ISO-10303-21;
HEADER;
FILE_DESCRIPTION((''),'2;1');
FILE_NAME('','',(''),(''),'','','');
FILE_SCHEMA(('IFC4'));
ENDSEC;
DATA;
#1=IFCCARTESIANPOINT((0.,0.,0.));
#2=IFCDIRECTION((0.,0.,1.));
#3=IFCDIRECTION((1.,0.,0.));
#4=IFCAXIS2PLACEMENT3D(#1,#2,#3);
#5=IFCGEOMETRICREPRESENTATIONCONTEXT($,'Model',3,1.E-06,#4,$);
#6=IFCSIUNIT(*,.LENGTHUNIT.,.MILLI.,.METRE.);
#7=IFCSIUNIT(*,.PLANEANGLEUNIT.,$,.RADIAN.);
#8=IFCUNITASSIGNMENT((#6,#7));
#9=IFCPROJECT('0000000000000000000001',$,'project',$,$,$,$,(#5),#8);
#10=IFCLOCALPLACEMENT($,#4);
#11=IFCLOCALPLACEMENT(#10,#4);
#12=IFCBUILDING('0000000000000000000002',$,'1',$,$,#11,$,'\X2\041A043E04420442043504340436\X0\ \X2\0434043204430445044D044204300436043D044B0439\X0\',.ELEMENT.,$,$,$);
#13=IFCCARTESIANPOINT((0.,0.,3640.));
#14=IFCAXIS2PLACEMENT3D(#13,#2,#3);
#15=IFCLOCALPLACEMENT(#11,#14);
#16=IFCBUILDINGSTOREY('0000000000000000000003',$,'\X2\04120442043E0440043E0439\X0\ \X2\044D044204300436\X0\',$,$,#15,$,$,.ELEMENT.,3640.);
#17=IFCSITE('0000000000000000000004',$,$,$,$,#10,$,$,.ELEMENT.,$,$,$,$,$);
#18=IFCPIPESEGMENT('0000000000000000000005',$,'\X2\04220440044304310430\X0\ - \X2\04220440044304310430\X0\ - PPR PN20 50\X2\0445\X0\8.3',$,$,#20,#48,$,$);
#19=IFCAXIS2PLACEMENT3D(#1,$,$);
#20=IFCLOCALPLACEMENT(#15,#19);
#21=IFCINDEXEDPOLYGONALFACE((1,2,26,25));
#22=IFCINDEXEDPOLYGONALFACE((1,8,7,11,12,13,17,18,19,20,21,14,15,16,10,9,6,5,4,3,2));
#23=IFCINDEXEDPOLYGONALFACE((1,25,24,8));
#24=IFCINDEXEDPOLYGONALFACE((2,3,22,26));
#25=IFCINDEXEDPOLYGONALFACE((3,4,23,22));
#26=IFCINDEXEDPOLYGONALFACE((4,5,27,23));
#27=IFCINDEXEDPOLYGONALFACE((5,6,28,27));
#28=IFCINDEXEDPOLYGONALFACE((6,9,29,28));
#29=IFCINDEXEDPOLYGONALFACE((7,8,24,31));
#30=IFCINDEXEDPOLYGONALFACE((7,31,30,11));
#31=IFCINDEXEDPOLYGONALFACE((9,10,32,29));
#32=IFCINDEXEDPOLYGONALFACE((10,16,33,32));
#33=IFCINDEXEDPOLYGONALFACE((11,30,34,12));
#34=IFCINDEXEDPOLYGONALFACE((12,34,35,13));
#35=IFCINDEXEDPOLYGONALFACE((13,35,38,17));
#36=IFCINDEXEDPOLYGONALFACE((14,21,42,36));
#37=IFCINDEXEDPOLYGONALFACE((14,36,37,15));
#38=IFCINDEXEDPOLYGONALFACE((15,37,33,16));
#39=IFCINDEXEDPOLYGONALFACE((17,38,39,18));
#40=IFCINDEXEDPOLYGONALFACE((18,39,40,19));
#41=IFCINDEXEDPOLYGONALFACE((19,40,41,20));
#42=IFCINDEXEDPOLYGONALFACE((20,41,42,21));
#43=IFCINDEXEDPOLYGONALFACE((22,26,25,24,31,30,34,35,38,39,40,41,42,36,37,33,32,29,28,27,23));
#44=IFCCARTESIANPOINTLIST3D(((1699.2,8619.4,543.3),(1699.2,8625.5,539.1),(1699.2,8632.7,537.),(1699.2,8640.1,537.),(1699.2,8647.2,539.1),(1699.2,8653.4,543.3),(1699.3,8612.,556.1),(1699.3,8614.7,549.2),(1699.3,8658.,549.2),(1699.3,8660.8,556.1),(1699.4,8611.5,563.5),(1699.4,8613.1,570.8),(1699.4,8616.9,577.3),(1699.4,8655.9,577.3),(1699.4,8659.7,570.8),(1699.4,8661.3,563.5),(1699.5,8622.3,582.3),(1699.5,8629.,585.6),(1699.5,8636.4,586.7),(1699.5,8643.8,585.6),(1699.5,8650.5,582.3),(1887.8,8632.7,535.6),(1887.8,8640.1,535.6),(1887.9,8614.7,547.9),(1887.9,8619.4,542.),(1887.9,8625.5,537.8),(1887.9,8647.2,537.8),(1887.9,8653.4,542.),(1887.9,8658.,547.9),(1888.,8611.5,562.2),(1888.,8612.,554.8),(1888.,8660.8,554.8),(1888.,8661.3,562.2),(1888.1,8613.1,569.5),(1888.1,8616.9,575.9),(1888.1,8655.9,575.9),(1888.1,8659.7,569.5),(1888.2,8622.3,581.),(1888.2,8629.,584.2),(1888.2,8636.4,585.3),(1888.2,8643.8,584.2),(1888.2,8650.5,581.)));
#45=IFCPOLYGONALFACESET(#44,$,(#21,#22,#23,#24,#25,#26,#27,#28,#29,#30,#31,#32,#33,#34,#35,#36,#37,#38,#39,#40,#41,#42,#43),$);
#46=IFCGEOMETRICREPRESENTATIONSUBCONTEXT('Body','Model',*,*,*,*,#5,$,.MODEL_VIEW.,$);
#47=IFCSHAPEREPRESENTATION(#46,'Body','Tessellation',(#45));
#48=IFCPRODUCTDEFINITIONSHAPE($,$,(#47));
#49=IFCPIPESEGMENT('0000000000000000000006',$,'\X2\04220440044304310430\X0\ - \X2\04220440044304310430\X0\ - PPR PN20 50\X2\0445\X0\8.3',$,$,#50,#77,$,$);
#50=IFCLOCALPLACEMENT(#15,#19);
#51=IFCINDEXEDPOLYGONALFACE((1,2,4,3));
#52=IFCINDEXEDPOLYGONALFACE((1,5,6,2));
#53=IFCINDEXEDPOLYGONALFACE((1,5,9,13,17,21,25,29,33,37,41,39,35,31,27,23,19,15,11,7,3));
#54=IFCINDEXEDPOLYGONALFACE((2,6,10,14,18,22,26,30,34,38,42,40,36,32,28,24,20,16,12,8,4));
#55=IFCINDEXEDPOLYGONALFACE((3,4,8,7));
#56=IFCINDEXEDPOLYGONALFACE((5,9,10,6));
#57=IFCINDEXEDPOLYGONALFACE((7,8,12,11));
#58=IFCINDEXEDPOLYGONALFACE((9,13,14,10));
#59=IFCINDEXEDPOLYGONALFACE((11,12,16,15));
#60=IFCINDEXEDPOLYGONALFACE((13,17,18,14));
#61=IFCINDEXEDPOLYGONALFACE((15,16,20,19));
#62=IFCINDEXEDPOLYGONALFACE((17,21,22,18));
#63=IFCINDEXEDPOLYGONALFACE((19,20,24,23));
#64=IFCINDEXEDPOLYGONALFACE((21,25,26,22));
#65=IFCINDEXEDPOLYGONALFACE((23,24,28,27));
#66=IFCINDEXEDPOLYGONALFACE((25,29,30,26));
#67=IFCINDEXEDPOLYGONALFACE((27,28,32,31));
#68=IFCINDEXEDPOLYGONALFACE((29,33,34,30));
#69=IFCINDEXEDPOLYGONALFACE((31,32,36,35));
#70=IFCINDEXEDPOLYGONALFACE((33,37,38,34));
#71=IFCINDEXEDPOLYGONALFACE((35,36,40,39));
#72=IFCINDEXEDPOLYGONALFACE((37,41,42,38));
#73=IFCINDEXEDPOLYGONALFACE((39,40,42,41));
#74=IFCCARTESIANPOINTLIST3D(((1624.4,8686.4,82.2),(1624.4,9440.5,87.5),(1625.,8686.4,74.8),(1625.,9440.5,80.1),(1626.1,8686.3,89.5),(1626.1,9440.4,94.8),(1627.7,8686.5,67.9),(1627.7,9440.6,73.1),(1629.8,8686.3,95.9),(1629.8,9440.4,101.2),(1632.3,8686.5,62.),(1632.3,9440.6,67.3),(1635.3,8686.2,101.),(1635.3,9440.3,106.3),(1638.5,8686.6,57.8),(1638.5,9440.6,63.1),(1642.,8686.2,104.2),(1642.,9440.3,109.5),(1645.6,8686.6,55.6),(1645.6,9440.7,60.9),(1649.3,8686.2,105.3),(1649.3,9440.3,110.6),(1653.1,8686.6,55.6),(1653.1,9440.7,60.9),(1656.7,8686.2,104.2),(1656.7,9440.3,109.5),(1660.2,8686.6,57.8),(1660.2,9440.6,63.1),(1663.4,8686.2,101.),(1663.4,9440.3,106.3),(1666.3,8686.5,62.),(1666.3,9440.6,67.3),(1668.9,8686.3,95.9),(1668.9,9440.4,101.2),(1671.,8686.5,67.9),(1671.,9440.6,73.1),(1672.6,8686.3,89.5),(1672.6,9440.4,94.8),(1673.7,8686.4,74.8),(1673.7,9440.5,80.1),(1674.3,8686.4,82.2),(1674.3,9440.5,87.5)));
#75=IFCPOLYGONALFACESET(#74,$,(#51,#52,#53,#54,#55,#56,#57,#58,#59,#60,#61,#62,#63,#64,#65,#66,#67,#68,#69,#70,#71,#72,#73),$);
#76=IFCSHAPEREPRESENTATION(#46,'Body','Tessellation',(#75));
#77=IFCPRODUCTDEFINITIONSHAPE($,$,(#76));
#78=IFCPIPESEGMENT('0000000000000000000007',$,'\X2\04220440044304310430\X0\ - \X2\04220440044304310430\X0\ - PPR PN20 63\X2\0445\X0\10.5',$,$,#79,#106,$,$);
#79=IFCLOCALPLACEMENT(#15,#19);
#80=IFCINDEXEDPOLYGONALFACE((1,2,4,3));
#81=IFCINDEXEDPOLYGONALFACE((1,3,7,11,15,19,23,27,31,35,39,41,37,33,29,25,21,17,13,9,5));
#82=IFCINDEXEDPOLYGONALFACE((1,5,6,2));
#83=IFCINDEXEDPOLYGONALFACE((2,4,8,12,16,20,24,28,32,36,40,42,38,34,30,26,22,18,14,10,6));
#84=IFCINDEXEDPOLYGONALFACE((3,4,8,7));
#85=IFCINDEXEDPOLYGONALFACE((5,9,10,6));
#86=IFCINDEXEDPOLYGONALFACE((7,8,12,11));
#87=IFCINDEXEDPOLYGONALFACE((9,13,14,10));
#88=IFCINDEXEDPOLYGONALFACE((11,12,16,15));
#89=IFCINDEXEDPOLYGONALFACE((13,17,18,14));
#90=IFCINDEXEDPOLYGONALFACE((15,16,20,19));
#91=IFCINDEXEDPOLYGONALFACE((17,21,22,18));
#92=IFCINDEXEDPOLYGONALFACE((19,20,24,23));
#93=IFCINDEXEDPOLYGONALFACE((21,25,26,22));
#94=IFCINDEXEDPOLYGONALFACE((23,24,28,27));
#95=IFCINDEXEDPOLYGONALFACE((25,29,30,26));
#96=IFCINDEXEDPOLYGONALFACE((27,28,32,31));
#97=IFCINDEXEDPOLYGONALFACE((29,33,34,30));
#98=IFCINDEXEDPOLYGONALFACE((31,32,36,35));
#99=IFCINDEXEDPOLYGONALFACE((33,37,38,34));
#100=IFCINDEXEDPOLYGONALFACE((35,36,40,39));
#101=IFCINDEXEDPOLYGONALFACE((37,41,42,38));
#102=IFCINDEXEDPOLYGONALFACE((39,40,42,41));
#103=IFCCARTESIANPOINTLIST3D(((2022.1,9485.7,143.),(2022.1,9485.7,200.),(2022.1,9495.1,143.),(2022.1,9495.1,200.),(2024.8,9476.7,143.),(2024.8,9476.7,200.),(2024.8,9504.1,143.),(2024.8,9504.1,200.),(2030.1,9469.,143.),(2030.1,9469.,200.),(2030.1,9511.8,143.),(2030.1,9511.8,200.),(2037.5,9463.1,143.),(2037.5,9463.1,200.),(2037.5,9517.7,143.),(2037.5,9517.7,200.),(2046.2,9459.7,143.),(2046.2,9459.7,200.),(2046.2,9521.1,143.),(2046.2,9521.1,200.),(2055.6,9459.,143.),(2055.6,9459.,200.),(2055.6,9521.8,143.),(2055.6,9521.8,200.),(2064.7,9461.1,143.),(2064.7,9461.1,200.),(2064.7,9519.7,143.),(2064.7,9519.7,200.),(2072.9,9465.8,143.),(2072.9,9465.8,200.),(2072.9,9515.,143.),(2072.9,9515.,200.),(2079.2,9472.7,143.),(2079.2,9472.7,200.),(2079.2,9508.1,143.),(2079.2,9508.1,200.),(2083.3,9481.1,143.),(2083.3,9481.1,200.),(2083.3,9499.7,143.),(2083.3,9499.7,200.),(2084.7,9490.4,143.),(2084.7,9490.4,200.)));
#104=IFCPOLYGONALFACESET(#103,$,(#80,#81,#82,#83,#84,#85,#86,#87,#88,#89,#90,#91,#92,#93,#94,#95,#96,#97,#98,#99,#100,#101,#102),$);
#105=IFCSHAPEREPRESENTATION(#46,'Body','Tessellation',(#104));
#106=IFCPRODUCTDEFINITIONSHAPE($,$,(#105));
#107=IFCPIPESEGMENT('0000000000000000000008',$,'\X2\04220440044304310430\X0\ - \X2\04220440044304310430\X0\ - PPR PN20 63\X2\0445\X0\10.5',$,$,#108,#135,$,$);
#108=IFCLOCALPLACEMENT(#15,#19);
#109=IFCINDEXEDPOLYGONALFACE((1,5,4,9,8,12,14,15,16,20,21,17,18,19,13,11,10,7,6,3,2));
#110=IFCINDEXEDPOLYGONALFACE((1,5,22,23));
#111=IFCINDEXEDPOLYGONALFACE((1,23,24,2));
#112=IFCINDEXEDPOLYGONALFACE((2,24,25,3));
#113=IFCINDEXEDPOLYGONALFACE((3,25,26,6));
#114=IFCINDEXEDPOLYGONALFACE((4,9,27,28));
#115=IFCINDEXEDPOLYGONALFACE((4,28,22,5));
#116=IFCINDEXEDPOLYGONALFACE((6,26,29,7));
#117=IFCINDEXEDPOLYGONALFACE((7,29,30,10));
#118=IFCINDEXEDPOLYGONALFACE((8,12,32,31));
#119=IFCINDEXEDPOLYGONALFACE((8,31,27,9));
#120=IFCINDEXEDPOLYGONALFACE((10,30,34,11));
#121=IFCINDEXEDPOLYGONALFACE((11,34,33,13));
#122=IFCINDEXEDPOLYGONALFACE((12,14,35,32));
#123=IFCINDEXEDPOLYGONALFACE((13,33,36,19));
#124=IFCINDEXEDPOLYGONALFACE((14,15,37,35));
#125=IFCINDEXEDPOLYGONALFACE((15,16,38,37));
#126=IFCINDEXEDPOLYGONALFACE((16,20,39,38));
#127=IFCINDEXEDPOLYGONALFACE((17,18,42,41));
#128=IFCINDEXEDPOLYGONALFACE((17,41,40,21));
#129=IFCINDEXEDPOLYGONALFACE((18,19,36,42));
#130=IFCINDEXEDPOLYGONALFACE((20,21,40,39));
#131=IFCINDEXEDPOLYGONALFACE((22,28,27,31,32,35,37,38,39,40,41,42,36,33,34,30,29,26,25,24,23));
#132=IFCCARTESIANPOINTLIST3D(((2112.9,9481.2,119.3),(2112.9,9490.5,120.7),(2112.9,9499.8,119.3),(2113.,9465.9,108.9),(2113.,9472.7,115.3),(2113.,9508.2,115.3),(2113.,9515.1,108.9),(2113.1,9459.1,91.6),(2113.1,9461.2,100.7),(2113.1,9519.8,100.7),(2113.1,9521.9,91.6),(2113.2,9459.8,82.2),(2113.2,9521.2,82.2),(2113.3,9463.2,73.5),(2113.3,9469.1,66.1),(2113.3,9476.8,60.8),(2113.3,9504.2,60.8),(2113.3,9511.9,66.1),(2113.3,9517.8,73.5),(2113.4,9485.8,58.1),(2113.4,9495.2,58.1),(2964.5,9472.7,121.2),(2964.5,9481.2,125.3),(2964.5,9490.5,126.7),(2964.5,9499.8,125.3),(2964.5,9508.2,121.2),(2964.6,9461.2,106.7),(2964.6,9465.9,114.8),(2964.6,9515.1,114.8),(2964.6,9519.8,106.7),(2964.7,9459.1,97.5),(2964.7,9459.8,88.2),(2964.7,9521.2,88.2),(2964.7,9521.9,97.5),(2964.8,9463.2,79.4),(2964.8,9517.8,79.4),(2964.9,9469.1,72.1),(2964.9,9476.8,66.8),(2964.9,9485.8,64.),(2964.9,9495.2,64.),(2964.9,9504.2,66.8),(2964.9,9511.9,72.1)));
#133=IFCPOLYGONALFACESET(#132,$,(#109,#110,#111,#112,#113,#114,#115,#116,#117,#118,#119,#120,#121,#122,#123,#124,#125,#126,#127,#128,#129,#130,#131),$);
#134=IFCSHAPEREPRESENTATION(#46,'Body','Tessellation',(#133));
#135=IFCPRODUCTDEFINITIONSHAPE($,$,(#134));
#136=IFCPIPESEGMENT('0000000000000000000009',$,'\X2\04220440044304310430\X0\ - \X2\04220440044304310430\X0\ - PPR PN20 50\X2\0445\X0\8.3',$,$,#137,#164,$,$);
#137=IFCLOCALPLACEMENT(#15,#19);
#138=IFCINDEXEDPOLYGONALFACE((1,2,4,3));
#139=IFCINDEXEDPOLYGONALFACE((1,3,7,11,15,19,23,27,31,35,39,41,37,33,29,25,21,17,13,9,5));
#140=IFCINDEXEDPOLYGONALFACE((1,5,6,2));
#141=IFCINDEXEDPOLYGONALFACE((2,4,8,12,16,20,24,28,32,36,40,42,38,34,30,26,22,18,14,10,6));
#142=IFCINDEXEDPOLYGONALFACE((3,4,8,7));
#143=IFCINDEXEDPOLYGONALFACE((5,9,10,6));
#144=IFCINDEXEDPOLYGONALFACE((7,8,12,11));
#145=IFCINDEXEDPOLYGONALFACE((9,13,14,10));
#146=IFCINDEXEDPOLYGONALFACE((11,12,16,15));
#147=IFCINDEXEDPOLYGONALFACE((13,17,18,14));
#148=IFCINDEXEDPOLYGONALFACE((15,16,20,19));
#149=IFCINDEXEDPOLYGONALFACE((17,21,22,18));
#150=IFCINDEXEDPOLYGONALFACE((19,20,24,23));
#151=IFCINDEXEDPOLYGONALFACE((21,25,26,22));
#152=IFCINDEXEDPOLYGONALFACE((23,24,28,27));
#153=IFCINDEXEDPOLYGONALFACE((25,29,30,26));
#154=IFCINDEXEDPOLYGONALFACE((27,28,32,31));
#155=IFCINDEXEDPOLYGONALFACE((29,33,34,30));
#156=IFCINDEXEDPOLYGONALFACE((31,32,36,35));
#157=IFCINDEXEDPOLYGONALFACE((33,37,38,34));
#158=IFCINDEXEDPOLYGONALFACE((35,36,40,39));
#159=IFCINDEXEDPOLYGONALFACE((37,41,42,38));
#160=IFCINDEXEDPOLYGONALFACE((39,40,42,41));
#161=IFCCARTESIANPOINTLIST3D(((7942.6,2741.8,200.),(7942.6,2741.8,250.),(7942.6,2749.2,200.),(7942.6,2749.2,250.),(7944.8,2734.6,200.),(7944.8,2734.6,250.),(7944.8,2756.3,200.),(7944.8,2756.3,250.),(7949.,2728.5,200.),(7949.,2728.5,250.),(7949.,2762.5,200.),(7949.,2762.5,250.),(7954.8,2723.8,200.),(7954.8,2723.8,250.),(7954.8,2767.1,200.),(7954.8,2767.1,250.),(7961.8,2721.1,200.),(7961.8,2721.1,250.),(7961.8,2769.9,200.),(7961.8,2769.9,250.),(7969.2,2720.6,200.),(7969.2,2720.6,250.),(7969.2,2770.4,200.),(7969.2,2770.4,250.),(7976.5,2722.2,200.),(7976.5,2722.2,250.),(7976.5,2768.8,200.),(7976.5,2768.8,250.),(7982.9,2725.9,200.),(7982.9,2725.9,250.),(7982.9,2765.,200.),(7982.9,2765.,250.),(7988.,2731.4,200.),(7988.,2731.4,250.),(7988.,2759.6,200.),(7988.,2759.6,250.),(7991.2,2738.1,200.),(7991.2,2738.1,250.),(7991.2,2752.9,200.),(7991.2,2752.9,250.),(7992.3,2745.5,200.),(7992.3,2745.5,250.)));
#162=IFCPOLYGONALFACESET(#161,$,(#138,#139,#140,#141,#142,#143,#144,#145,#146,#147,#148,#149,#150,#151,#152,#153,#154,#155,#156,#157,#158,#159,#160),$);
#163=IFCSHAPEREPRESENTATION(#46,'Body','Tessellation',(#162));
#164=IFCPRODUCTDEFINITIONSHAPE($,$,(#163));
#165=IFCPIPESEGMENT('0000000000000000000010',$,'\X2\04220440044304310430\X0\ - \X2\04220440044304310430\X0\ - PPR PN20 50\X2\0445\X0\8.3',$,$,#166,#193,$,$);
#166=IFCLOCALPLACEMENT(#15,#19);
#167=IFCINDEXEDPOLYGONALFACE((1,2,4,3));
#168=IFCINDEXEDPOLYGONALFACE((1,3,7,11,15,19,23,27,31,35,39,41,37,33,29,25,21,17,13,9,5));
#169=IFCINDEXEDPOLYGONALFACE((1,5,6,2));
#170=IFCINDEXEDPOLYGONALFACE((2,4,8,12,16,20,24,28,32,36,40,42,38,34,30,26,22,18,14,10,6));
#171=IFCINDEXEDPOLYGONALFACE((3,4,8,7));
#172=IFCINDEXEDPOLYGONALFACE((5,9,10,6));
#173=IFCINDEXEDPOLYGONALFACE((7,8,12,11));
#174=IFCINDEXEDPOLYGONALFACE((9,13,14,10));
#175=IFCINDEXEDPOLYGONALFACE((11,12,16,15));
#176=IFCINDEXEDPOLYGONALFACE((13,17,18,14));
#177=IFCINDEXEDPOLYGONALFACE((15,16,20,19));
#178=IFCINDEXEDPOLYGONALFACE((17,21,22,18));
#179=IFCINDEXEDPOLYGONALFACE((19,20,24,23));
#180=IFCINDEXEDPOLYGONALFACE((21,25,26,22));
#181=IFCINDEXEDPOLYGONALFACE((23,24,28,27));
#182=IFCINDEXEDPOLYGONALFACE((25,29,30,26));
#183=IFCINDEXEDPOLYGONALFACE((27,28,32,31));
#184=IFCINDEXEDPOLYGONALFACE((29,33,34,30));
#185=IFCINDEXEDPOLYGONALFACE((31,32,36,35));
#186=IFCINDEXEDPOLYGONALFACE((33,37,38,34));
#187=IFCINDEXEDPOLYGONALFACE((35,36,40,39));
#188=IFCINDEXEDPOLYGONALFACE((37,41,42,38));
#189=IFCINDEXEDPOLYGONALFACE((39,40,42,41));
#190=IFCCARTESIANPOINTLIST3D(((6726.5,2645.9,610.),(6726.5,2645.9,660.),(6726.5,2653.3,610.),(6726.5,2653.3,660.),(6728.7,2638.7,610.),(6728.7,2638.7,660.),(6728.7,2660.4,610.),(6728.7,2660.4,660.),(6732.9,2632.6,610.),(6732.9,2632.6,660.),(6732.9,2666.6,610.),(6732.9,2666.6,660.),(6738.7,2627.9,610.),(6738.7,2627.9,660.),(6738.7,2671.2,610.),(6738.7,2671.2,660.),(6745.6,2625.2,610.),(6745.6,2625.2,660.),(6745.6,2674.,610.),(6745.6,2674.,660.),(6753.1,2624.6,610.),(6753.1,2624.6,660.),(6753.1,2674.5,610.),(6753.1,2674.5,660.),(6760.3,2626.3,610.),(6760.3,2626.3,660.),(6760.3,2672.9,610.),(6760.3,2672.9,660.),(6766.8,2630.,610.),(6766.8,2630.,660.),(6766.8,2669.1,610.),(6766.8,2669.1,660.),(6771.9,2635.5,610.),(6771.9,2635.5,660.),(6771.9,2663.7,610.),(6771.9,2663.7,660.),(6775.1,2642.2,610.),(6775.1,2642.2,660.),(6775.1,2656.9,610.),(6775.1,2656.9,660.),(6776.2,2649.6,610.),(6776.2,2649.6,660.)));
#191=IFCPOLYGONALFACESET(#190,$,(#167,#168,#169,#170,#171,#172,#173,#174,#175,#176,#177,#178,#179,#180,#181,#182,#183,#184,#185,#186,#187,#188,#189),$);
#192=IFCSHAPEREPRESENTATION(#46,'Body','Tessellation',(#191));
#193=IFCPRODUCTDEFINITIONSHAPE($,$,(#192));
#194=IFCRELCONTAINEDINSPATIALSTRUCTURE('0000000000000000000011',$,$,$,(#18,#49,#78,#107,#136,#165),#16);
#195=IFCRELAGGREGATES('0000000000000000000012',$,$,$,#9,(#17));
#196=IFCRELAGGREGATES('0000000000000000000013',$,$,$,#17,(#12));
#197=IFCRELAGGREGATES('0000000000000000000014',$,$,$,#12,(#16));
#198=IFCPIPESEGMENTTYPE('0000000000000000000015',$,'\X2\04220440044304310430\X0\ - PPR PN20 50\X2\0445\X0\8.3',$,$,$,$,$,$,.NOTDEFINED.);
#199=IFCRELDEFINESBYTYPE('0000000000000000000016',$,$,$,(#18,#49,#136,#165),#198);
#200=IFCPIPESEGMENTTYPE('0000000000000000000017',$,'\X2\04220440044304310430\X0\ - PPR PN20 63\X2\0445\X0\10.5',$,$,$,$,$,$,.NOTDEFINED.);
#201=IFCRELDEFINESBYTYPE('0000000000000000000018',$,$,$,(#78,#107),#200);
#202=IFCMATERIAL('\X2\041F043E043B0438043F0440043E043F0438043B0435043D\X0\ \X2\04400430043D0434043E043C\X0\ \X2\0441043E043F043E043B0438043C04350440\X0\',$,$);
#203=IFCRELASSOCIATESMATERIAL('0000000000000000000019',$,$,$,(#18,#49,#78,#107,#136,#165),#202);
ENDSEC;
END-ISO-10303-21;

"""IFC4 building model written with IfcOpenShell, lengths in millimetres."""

from ifc_helpers import new_model, entity, si_unit, frame, origin_with_axes, place, context, subcontext, project, spatial, source, transform, mapped, material, type_object, element, save


model = new_model("IFC4")

# Units and contexts
model_context = context("Model", 3, precision=1e-06, world=origin_with_axes())
body_context = subcontext(model_context, "Body", "Model", "MODEL_VIEW")
ifc_project = project(units=[si_unit("LENGTHUNIT", "METRE", prefix="MILLI"), si_unit("PLANEANGLEUNIT", "RADIAN")], contexts=[model_context])

# Site, building, storey
site_placement = place(None, origin_with_axes())
site = spatial("IfcSite", under=ifc_project, at=site_placement, CompositionType="ELEMENT")
building_placement = place(site_placement, origin_with_axes())
building = spatial("IfcBuilding", under=site, at=building_placement, Name="1", LongName="Коттедж двухэтажный", CompositionType="ELEMENT")
storey_placement = place(building_placement, frame((0.0, 0.0, 3640.0), z_axis=(0.0, 0.0, 1.0), x_axis=(1.0, 0.0, 0.0)))
storey = spatial("IfcBuildingStorey", under=building, at=storey_placement, Name="Второй этаж", CompositionType="ELEMENT", Elevation=3640.0)

# Pipe segments
ifc_material = material(Name="Полипропилен рандом сополимер")
pipe_segment_type_1 = type_object("IfcPipeSegmentType", Name="Труба - PPR PN20 63х10.5", PredefinedType="NOTDEFINED")
pipe_segment_type_2 = type_object("IfcPipeSegmentType", Name="Труба - PPR PN20 50х8.3", PredefinedType="NOTDEFINED")
shared_shape_1 = source(origin_with_axes(), body_context, "Body", "AdvancedSweptSolid", [
    entity("IfcSweptDiskSolid", entity("IfcIndexedPolyCurve", entity("IfcCartesianPointList3D", [[0.0, 0.0, 0.0], [188.7, 0.0, 1.3]]), [entity("IfcLineIndex", [1, 2])]), 25.0),
])
pipe_segment_1_placement = place(storey_placement, frame((1888.0, 8636.4, 560.3), z_axis=(0.0, 0.0, 1.0), x_axis=(-1.0, 0.0, 0.0)))
element("IfcPipeSegment", 1, at=pipe_segment_1_placement, inside=storey, type_object=pipe_segment_type_2, material=ifc_material, Name="Труба - Труба - PPR PN20 50х8.3", context=body_context, shape_type="MappedRepresentation", body=[
    mapped(shared_shape_1, transform((0.0, 0.0, 0.0), x_axis=(1.0, 0.0, 0.0), y_axis=(0.0, 1.0, 0.0), z_axis=(0.0, 0.0, 1.0), scale=1.0)),
])
shared_shape_2 = source(origin_with_axes(), body_context, "Body", "AdvancedSweptSolid", [
    entity("IfcSweptDiskSolid", entity("IfcIndexedPolyCurve", entity("IfcCartesianPointList3D", [[0.0, 0.0, 0.0], [754.1, 0.0, 5.3]]), [entity("IfcLineIndex", [1, 2])]), 25.0),
])
pipe_segment_2_placement = place(storey_placement, frame((1649.3, 8686.4, 80.3), z_axis=(0.0, 0.0, 1.0), x_axis=(0.0, 1.0, 0.0)))
element("IfcPipeSegment", 2, at=pipe_segment_2_placement, inside=storey, type_object=pipe_segment_type_2, material=ifc_material, Name="Труба - Труба - PPR PN20 50х8.3", context=body_context, shape_type="MappedRepresentation", body=[
    mapped(shared_shape_2, transform((0.0, 0.0, 0.0), x_axis=(1.0, 0.0, 0.0), y_axis=(0.0, 1.0, 0.0), z_axis=(0.0, 0.0, 1.0), scale=1.0)),
])
shared_shape_3 = source(origin_with_axes(), body_context, "Body", "AdvancedSweptSolid", [
    entity("IfcSweptDiskSolid", entity("IfcIndexedPolyCurve", entity("IfcCartesianPointList3D", [[0.0, 0.0, 0.0], [0.0, 0.0, 57.0]]), [entity("IfcLineIndex", [1, 2])]), 31.5),
])
pipe_segment_3_placement = place(storey_placement, frame((2053.2, 9490.4, 200.0), z_axis=(0.0, 0.0, -1.0), x_axis=(1.0, 0.0, 0.0)))
element("IfcPipeSegment", 3, at=pipe_segment_3_placement, inside=storey, type_object=pipe_segment_type_1, material=ifc_material, Name="Труба - Труба - PPR PN20 63х10.5", context=body_context, shape_type="MappedRepresentation", body=[
    mapped(shared_shape_3, transform((0.0, 0.0, 0.0), x_axis=(1.0, 0.0, 0.0), y_axis=(0.0, 1.0, 0.0), z_axis=(0.0, 0.0, 1.0), scale=1.0)),
])
shared_shape_4 = source(origin_with_axes(), body_context, "Body", "AdvancedSweptSolid", [
    entity("IfcSweptDiskSolid", entity("IfcIndexedPolyCurve", entity("IfcCartesianPointList3D", [[0.0, 0.0, 0.0], [851.5, 0.0, 6.0]]), [entity("IfcLineIndex", [1, 2])]), 31.5),
])
pipe_segment_4_placement = place(storey_placement, frame((2113.1, 9490.5, 89.2), z_axis=(0.0, 0.0, 1.0), x_axis=(1.0, 0.0, 0.0)))
element("IfcPipeSegment", 4, at=pipe_segment_4_placement, inside=storey, type_object=pipe_segment_type_1, material=ifc_material, Name="Труба - Труба - PPR PN20 63х10.5", context=body_context, shape_type="MappedRepresentation", body=[
    mapped(shared_shape_4, transform((0.0, 0.0, 0.0), x_axis=(1.0, 0.0, 0.0), y_axis=(0.0, 1.0, 0.0), z_axis=(0.0, 0.0, 1.0), scale=1.0)),
])
shared_shape_5 = source(origin_with_axes(), body_context, "Body", "AdvancedSweptSolid", [
    entity("IfcSweptDiskSolid", entity("IfcIndexedPolyCurve", entity("IfcCartesianPointList3D", [[0.0, 0.0, 0.0], [0.0, 0.0, 50.0]]), [entity("IfcLineIndex", [1, 2])]), 25.0),
])
for number, where, z_axis, x_axis, name in (
    (5, (7967.3, 2745.5, 250.0), (0.0, 0.0, -1.0), (1.0, 0.0, 0.0), "Труба - Труба - PPR PN20 50х8.3"),
    (6, (6751.2, 2649.6, 660.0), (0.0, 0.0, -1.0), (1.0, 0.0, 0.0), "Труба - Труба - PPR PN20 50х8.3"),
):
    element("IfcPipeSegment", number, at=place(storey_placement, frame(where, z_axis=z_axis, x_axis=x_axis)), inside=storey, type_object=pipe_segment_type_2, material=ifc_material, Name=name, context=body_context, shape_type="MappedRepresentation", body=[
        mapped(shared_shape_5, transform((0.0, 0.0, 0.0), x_axis=(1.0, 0.0, 0.0), y_axis=(0.0, 1.0, 0.0), z_axis=(0.0, 0.0, 1.0), scale=1.0)),
    ])

save(model, "model.ifc")
